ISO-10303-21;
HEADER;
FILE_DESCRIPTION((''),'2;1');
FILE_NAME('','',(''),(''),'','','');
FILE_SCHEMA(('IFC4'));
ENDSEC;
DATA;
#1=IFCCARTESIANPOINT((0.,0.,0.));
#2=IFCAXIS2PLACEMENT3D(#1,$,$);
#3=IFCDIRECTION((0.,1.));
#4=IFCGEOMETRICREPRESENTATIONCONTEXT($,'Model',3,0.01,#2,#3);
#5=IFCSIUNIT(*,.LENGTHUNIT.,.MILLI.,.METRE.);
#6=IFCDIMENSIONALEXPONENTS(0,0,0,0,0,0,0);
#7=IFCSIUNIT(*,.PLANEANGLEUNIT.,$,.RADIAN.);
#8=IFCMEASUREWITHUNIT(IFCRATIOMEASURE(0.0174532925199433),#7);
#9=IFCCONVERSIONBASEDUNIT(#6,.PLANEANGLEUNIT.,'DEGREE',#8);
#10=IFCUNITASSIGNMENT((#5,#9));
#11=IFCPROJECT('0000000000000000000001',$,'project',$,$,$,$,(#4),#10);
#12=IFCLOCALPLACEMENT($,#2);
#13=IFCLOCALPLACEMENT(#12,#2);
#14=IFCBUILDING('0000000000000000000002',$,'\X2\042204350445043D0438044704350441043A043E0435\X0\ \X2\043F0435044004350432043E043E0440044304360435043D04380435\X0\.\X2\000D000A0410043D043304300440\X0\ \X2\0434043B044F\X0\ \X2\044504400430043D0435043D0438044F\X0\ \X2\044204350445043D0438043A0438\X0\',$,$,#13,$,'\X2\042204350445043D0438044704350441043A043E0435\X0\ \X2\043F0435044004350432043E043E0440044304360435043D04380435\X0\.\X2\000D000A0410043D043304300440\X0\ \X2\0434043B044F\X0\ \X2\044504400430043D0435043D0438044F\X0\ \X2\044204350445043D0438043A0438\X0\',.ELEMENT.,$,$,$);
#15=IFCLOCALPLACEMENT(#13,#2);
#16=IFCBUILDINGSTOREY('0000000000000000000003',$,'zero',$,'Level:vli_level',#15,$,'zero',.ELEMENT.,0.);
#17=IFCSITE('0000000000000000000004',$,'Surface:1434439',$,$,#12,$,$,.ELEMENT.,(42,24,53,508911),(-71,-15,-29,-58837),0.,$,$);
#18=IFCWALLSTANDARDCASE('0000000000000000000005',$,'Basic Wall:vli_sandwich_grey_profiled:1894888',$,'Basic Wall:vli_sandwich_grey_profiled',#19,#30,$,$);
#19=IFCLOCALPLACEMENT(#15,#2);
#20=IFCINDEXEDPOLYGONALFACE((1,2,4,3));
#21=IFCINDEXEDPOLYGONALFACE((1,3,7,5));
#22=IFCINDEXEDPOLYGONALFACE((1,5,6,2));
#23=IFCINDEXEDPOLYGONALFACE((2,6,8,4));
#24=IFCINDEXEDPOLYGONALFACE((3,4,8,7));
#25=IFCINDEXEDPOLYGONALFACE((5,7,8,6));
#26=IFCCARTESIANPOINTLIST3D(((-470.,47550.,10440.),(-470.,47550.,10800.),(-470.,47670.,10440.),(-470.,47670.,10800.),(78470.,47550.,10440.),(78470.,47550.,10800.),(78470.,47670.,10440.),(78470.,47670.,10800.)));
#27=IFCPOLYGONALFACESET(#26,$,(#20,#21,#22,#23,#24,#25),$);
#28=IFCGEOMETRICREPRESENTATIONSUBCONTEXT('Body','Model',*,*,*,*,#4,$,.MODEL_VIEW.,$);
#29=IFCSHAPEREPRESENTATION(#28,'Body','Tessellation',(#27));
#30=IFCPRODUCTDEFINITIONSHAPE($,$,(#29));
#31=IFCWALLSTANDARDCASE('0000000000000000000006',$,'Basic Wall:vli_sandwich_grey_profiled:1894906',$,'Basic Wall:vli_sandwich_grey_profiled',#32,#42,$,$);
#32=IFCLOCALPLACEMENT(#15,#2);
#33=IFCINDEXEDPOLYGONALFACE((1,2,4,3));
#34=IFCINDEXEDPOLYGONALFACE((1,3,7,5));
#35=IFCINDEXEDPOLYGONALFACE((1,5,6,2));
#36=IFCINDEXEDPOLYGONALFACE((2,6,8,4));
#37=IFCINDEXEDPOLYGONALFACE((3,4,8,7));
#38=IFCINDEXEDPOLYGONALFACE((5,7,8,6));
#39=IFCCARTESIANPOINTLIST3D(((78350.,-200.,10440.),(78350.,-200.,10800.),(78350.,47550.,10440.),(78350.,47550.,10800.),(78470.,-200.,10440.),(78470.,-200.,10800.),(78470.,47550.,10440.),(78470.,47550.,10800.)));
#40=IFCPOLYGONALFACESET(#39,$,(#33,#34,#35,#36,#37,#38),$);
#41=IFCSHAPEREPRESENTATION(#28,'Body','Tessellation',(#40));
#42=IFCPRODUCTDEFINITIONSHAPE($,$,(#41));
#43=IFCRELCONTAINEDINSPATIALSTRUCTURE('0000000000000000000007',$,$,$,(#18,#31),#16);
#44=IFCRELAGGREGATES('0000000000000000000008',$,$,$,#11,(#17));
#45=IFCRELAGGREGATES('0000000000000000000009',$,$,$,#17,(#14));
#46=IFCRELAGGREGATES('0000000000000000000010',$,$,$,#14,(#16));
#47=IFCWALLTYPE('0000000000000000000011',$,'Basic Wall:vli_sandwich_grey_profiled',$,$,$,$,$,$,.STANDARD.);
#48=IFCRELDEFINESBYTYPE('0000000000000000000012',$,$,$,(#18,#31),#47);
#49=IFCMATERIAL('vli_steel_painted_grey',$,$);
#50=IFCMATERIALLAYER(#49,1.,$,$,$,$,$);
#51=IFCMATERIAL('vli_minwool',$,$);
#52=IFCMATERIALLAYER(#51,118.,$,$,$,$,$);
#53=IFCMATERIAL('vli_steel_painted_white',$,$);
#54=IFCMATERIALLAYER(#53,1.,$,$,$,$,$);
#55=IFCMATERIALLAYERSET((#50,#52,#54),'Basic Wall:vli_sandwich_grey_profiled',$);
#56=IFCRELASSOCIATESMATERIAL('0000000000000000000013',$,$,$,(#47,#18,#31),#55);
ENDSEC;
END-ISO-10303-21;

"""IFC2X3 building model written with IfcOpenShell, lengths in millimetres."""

from ifc_helpers import new_model, entity, si_unit, converted_unit, direction, frame, frame_2d, origin, place, context, subcontext, project, spatial, rectangle, extrude, material, layer, layer_set, layer_usage, type_object, element, save


model = new_model("IFC2X3")

# Units and contexts
model_context = context("Model", 3, precision=0.01, world=origin(), true_north=direction((0.0, 1.0)))
body_context = subcontext(model_context, "Body", "Model", "MODEL_VIEW")
ifc_project = project(units=[si_unit("LENGTHUNIT", "METRE", prefix="MILLI"), converted_unit("PLANEANGLEUNIT", "DEGREE", entity("IfcRatioMeasure", 0.0174532925199433), si_unit("PLANEANGLEUNIT", "RADIAN"), dimensions=[0, 0, 0, 0, 0, 0, 0])], contexts=[model_context])

# Site, building, storey
site_placement = place(None, origin())
site = spatial("IfcSite", under=ifc_project, at=site_placement, Name="Surface:1434439", CompositionType="ELEMENT", RefLatitude=(42, 24, 53, 508911), RefLongitude=(-71, -15, -29, -58837), RefElevation=0.0)
building_placement = place(site_placement, origin())
building = spatial("IfcBuilding", under=site, at=building_placement, Name="Техническое перевооружение.\r\nАнгар для хранения техники", LongName="Техническое перевооружение.\r\nАнгар для хранения техники", CompositionType="ELEMENT")
storey_placement = place(building_placement, origin())
storey = spatial("IfcBuildingStorey", under=building, at=storey_placement, Name="zero", ObjectType="Level:vli_level", LongName="zero", CompositionType="ELEMENT", Elevation=0.0)

# Walls
ifc_material_1 = material(Name="vli_steel_painted_grey")
ifc_layer_1 = layer(ifc_material_1, 1.0)
ifc_material_2 = material(Name="vli_minwool")
ifc_layer_2 = layer(ifc_material_2, 118.0)
ifc_material_3 = material(Name="vli_steel_painted_white")
ifc_layer_3 = layer(ifc_material_3, 1.0)
ifc_layer_set = layer_set([ifc_layer_1, ifc_layer_2, ifc_layer_3], Name="Basic Wall:vli_sandwich_grey_profiled")
ifc_layer_usage_1 = layer_usage(ifc_layer_set, "AXIS2", "POSITIVE", -60.0)
wall_type = type_object("IfcWallType", Name="Basic Wall:vli_sandwich_grey_profiled", PredefinedType="STANDARD", material=ifc_layer_set)
wall_1_placement = place(storey_placement, frame((78470.0, 47610.0, 10440.0), z_axis=(0.0, 0.0, 1.0), x_axis=(-1.0, 0.0, 0.0)))
element("IfcWallStandardCase", 1, at=wall_1_placement, inside=storey, type_object=wall_type, material=ifc_layer_usage_1, Name="Basic Wall:vli_sandwich_grey_profiled:1894888", ObjectType="Basic Wall:vli_sandwich_grey_profiled", context=body_context, shape_type="SweptSolid", body=[
    extrude(rectangle(XDim=78940.0, YDim=120.0, at=frame_2d((39470.0, 0.0), x_axis=(-1.0, 0.0))), origin(), (0.0, 0.0, 1.0), 360.0),
])
ifc_layer_usage_2 = layer_usage(ifc_layer_set, "AXIS2", "POSITIVE", -60.0)
wall_2_placement = place(storey_placement, frame((78410.0, -200.0, 10440.0), z_axis=(0.0, 0.0, 1.0), x_axis=(0.0, 1.0, 0.0)))
element("IfcWallStandardCase", 2, at=wall_2_placement, inside=storey, type_object=wall_type, material=ifc_layer_usage_2, Name="Basic Wall:vli_sandwich_grey_profiled:1894906", ObjectType="Basic Wall:vli_sandwich_grey_profiled", context=body_context, shape_type="SweptSolid", body=[
    extrude(rectangle(XDim=47750.0, YDim=120.0, at=frame_2d((23875.0, 0.0), x_axis=(-1.0, 0.0))), origin(), (0.0, 0.0, 1.0), 360.0),
])

save(model, "model.ifc")
